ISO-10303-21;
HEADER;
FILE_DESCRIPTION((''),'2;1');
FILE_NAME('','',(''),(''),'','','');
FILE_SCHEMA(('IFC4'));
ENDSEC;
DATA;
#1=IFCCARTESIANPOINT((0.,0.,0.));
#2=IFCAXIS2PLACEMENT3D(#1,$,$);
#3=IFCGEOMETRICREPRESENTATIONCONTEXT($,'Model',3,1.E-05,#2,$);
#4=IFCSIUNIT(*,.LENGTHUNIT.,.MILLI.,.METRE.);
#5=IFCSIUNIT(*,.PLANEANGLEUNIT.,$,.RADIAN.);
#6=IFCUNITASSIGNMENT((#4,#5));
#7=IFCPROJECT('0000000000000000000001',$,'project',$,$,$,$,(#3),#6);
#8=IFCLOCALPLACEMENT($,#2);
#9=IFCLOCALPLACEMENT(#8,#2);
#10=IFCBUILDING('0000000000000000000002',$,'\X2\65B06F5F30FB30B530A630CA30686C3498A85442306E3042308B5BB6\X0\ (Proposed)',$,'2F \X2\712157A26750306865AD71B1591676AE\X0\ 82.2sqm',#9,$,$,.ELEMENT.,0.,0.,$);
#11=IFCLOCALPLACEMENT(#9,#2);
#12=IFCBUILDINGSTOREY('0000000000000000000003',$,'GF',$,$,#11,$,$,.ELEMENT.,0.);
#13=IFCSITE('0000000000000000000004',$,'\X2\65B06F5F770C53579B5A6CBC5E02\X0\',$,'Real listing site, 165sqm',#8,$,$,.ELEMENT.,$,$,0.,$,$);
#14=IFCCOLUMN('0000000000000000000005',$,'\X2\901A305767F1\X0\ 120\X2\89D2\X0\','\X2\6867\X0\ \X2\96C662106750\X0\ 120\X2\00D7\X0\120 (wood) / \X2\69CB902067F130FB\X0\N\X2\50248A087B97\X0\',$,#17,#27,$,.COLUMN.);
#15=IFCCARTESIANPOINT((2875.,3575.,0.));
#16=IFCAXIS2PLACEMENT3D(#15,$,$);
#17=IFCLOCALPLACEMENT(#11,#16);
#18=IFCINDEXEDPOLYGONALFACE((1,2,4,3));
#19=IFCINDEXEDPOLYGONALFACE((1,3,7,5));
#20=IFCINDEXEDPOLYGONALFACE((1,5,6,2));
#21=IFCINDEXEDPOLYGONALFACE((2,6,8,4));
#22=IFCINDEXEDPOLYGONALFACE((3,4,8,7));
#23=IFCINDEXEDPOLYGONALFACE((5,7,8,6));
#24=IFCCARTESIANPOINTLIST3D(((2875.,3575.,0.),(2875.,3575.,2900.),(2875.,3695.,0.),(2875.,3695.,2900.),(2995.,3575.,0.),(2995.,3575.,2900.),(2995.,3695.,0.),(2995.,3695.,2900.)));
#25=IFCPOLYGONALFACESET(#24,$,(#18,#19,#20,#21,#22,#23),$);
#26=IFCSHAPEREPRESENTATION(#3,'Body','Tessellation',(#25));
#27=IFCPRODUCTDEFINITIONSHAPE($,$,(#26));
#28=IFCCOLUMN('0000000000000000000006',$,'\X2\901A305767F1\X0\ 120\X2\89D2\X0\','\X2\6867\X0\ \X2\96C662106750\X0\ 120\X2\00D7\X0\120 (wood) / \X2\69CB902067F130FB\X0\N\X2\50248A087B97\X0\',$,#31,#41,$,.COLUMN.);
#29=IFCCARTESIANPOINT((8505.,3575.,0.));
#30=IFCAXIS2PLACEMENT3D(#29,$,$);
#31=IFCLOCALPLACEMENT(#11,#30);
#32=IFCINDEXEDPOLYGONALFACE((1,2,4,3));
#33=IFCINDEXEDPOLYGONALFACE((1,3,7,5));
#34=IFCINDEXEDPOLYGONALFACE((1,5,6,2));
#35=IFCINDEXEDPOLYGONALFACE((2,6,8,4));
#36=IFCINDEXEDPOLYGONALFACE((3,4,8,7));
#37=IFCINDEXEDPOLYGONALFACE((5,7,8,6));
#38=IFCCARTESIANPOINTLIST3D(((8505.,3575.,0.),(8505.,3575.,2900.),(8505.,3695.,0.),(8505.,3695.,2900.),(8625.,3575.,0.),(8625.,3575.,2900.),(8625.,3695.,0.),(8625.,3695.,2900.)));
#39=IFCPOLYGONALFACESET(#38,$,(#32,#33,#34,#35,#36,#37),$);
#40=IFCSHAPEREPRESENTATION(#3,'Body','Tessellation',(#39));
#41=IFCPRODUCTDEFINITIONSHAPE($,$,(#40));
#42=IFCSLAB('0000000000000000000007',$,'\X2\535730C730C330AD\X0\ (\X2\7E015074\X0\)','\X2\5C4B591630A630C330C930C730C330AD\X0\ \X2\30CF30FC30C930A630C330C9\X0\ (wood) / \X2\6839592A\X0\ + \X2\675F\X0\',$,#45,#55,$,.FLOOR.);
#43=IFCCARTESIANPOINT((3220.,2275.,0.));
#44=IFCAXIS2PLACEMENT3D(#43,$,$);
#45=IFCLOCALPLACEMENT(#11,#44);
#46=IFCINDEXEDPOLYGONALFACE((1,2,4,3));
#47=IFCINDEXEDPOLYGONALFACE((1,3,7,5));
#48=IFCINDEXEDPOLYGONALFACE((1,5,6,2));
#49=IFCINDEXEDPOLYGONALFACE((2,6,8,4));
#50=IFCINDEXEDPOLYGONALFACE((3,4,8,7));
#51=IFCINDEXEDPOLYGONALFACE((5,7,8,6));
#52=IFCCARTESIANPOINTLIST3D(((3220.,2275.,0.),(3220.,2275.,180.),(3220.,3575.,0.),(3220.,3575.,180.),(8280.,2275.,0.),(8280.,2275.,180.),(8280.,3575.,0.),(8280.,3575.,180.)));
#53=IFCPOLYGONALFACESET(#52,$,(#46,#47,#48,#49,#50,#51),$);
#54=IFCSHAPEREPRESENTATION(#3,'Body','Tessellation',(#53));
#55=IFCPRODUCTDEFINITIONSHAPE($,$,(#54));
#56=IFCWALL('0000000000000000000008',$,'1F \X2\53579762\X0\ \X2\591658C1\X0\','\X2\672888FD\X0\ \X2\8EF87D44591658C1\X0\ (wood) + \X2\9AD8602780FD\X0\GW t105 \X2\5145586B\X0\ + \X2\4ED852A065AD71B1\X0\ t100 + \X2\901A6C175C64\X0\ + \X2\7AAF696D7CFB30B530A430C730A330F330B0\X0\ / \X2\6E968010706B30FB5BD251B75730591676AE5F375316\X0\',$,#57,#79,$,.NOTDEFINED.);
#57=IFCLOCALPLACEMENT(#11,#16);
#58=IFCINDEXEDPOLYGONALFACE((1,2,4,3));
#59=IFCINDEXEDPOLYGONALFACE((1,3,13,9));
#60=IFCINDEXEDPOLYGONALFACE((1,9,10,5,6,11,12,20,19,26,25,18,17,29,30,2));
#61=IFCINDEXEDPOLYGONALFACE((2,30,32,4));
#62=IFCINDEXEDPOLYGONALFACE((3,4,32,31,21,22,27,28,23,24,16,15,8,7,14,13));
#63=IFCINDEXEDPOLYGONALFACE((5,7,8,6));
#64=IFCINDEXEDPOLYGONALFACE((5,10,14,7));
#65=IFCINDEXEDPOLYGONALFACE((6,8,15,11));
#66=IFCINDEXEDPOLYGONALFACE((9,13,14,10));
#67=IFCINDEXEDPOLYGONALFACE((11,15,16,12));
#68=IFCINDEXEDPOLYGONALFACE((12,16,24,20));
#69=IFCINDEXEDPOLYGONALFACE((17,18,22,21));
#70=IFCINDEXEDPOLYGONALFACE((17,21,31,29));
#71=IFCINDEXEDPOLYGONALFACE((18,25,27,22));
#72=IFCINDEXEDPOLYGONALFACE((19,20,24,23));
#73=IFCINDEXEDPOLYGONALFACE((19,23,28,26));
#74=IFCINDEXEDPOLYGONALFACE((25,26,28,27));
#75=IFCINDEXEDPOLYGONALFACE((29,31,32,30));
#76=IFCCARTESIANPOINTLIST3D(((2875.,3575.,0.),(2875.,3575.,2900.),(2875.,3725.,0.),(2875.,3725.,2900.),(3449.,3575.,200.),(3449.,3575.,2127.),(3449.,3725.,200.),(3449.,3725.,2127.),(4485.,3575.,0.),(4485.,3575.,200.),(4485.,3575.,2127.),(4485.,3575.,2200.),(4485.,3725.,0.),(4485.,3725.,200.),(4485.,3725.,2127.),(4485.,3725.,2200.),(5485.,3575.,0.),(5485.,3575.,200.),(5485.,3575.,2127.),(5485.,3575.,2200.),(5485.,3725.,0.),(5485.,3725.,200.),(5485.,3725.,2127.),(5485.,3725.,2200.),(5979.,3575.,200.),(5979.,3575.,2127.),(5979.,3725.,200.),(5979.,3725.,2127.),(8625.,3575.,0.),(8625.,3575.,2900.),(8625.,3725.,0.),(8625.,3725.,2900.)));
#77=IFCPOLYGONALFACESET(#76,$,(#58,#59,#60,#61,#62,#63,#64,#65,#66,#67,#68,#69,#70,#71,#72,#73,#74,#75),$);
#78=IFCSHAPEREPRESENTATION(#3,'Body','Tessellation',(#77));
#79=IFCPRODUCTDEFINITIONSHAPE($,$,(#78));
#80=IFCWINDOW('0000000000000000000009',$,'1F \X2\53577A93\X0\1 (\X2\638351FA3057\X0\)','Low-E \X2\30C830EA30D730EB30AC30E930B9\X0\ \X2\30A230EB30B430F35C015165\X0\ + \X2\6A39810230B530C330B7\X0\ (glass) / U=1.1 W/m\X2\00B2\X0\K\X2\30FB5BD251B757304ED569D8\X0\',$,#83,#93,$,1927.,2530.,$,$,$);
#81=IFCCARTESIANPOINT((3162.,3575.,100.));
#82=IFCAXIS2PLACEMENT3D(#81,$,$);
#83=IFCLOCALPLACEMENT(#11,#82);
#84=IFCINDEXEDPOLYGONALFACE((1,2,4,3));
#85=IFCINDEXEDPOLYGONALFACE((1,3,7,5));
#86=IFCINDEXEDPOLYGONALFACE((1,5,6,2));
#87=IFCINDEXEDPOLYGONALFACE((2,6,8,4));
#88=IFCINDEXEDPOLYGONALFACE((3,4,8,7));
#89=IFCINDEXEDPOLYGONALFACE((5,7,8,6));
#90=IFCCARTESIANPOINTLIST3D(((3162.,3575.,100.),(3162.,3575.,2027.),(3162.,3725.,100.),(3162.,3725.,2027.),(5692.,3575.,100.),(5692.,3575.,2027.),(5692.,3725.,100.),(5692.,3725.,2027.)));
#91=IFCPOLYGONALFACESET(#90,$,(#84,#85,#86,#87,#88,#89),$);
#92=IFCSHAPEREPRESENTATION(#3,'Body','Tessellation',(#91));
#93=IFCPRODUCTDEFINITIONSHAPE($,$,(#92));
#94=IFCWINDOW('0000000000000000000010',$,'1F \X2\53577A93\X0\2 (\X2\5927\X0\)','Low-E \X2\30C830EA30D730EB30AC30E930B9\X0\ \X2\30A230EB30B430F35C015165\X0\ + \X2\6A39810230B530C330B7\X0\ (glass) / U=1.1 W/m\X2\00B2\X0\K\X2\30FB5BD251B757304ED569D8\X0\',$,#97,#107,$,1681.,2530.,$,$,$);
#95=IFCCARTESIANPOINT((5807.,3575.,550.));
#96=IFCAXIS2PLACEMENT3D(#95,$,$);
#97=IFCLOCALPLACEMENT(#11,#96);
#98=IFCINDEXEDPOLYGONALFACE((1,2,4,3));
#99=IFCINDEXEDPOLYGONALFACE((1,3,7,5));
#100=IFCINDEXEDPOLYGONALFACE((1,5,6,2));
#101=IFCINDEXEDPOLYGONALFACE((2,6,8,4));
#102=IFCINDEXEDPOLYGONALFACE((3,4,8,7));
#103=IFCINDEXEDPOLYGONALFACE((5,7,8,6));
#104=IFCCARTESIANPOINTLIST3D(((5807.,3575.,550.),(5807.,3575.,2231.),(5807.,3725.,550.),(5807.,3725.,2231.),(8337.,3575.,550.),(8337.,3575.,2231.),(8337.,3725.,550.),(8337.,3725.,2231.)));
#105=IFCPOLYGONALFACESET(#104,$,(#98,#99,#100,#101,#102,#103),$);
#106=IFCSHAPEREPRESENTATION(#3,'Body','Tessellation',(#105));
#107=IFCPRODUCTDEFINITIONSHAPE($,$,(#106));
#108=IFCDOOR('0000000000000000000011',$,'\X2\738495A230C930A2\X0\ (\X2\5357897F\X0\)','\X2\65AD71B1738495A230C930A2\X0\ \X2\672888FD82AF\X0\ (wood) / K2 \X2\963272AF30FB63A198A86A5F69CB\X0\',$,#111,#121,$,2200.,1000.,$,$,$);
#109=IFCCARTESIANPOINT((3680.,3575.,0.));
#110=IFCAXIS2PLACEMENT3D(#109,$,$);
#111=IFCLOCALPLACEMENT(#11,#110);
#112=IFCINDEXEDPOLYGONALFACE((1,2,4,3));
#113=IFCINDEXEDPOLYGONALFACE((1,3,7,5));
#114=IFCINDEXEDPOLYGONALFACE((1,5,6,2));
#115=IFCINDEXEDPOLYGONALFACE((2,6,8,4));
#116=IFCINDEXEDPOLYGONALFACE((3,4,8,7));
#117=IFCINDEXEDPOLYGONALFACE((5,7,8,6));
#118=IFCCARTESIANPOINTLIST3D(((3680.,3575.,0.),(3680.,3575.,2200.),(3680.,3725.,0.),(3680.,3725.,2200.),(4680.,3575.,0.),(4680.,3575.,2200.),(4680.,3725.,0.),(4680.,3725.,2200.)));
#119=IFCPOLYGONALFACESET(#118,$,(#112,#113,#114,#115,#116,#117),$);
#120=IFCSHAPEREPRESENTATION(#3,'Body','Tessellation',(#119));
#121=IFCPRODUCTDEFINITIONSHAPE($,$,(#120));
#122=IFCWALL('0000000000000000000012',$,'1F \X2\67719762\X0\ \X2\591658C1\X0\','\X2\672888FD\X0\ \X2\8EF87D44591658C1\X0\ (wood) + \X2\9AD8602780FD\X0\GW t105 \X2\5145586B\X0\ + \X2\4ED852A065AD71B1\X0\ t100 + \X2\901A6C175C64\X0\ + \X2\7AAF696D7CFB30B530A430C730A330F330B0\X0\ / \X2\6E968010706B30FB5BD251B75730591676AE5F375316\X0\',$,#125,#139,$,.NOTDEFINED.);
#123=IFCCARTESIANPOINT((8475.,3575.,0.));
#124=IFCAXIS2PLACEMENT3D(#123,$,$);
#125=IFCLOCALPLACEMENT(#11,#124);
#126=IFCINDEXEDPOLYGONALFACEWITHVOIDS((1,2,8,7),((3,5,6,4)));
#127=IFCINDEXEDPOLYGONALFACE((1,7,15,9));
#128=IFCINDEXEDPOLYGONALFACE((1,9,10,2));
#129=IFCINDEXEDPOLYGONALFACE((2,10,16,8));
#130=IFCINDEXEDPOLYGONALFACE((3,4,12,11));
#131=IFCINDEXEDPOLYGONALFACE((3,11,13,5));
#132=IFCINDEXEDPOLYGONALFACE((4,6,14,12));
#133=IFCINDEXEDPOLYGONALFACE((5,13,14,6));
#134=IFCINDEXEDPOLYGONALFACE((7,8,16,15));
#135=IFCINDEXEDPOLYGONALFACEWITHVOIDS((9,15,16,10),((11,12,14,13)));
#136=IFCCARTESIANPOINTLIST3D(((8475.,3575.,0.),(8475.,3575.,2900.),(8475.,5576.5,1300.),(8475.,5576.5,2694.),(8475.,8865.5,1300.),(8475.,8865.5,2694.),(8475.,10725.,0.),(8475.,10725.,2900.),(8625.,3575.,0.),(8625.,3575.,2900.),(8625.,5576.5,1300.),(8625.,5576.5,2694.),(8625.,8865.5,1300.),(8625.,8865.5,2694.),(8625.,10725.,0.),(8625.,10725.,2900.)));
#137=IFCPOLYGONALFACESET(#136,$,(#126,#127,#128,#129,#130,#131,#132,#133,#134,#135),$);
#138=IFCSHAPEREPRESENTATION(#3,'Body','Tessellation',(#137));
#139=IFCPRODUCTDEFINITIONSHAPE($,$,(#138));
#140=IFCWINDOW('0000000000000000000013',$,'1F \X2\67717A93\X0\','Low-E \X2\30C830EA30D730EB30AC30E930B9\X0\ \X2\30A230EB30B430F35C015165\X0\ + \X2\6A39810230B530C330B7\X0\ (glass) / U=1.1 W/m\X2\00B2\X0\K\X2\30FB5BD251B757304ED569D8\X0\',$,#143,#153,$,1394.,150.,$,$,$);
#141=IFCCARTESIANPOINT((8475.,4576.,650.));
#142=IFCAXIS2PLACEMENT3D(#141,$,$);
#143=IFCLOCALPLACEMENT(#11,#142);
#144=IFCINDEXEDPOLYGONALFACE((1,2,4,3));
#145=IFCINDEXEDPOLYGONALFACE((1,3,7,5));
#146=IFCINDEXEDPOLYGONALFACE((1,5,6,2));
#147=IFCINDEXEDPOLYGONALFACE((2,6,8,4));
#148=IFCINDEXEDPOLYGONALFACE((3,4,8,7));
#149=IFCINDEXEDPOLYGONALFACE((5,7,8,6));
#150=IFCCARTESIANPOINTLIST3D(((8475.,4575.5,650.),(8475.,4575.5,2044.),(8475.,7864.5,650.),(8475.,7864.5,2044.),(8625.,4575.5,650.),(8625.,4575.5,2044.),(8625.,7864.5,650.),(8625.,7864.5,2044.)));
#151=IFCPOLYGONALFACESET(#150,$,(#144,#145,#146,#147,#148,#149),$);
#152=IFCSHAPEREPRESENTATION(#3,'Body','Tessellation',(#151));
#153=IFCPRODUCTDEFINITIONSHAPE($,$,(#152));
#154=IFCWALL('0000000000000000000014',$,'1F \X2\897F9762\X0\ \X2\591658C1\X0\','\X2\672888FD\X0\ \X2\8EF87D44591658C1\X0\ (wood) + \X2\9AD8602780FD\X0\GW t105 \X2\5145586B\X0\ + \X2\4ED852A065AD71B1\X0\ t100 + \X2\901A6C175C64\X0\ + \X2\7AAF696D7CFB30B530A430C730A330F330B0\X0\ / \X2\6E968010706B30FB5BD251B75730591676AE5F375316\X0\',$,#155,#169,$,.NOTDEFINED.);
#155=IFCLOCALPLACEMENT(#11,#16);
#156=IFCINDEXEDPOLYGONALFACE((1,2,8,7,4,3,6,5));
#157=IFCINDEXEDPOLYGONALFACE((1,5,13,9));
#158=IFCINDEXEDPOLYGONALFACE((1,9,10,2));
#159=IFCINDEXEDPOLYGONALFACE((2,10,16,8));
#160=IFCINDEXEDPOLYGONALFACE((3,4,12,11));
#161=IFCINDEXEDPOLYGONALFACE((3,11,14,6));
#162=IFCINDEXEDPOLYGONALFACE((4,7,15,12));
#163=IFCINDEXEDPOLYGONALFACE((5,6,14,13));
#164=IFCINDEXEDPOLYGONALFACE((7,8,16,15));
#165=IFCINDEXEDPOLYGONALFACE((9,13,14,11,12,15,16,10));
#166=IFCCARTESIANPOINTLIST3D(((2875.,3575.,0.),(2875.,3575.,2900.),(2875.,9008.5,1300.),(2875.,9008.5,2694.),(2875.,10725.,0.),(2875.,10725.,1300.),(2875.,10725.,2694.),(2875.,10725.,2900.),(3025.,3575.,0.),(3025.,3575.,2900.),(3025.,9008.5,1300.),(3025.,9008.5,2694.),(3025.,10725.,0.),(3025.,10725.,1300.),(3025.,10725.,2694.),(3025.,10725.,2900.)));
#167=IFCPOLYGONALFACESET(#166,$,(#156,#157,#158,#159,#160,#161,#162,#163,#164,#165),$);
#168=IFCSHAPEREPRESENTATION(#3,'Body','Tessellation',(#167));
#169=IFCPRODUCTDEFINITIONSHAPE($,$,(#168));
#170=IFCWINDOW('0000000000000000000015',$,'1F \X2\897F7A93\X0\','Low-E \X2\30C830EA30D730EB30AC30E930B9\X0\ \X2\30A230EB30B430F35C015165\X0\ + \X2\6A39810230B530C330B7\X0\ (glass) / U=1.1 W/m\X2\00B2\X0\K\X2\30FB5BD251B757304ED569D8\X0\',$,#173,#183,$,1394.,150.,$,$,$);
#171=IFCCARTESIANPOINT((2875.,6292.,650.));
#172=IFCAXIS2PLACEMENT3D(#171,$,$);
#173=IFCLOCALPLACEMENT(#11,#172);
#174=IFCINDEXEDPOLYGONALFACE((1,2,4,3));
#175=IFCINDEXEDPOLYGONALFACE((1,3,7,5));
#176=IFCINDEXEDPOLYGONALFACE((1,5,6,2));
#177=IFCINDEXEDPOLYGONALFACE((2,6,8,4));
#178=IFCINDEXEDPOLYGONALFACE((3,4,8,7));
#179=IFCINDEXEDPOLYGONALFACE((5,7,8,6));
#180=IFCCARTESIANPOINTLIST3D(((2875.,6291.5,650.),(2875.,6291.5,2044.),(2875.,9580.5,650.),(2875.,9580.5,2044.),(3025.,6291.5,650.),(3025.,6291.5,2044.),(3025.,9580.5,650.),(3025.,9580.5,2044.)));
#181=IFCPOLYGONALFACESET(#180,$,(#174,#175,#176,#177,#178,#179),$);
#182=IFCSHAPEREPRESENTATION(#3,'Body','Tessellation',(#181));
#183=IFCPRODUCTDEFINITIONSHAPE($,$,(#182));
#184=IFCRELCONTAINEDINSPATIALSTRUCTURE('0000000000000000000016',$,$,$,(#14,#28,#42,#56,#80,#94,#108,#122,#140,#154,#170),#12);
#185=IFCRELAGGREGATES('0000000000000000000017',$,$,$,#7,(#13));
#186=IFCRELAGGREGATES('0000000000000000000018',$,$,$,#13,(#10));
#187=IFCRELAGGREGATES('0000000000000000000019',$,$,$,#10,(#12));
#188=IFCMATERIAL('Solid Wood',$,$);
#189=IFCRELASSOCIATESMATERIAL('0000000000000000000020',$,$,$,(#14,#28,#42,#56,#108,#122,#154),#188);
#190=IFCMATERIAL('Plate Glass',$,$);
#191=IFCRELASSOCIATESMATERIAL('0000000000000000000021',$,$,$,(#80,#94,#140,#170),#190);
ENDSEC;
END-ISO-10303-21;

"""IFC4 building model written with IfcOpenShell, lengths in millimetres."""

from ifc_helpers import new_model, si_unit, frame, frame_2d, origin, place, context, project, spatial, rectangle, extrude, material, element, fill, save


model = new_model("IFC4")

# Units and contexts
model_context = context("Model", 3, precision=1e-05, world=origin())
ifc_project = project(units=[si_unit("LENGTHUNIT", "METRE", prefix="MILLI"), si_unit("PLANEANGLEUNIT", "RADIAN")], contexts=[model_context])

# Site, building, storey
site_placement = place(None, origin())
site = spatial("IfcSite", under=ifc_project, at=site_placement, Name="新潟県南魚沼市", ObjectType="Real listing site, 165sqm", CompositionType="ELEMENT", RefElevation=0.0)
building_placement = place(site_placement, origin())
building = spatial("IfcBuilding", under=site, at=building_placement, Name="新潟・サウナと水風呂のある家 (Proposed)", ObjectType="2F 無垢材と断熱外皮 82.2sqm", CompositionType="ELEMENT", ElevationOfRefHeight=0.0, ElevationOfTerrain=0.0)
storey_placement = place(building_placement, origin())
storey = spatial("IfcBuildingStorey", under=building, at=storey_placement, Name="GF", CompositionType="ELEMENT", Elevation=0.0)

# Columns
ifc_material_1 = material(Name="Solid Wood")
column_1_placement = place(storey_placement, frame((2875.0, 3575.0, 0.0)))
element("IfcColumn", 1, at=column_1_placement, inside=storey, material=ifc_material_1, Name="通し柱 120角", Description="桧 集成材 120×120 (wood) / 構造柱・N値計算", PredefinedType="COLUMN", context=model_context, shape_type="SweptSolid", body=[
    extrude(rectangle(XDim=120.0, YDim=120.0, at=frame_2d((60.0, 60.0))), frame((2875.0, 3575.0, 0.0)), (0.0, 0.0, 1.0), 2900.0),
])
column_2_placement = place(storey_placement, frame((8505.0, 3575.0, 0.0)))
element("IfcColumn", 2, at=column_2_placement, inside=storey, material=ifc_material_1, Name="通し柱 120角", Description="桧 集成材 120×120 (wood) / 構造柱・N値計算", PredefinedType="COLUMN", context=model_context, shape_type="SweptSolid", body=[
    extrude(rectangle(XDim=120.0, YDim=120.0, at=frame_2d((60.0, 60.0))), frame((8505.0, 3575.0, 0.0)), (0.0, 0.0, 1.0), 2900.0),
])

# Slab
slab_1_placement = place(storey_placement, frame((3220.0, 2275.0, 0.0)))
element("IfcSlab", 3, at=slab_1_placement, inside=storey, material=ifc_material_1, Name="南デッキ (縁側)", Description="屋外ウッドデッキ ハードウッド (wood) / 根太 + 束", PredefinedType="FLOOR", context=model_context, shape_type="SweptSolid", body=[
    extrude(rectangle(XDim=5060.0, YDim=1300.0, at=frame_2d((2530.0, 650.0))), frame((3220.0, 2275.0, 0.0)), (0.0, 0.0, 1.0), 180.0),
])

# Wall, openings, windows, door
wall_1_placement = place(storey_placement, frame((2875.0, 3575.0, 0.0)))
wall_1 = element("IfcWall", 4, at=wall_1_placement, inside=storey, material=ifc_material_1, Name="1F 南面 外壁", Description="木製 軸組外壁 (wood) + 高性能GW t105 充填 + 付加断熱 t100 + 通気層 + 窯業系サイディング / 準耐火・寒冷地外皮強化", PredefinedType="NOTDEFINED", context=model_context, shape_type="SweptSolid", body=[
    extrude(rectangle(XDim=5750.0, YDim=150.0, at=frame_2d((2875.0, 75.0))), frame((2875.0, 3575.0, 0.0)), (0.0, 0.0, 1.0), 2900.0),
])
opening_1_placement = place(storey_placement, frame((3162.0, 3575.0, 100.0)))
opening_1 = element("IfcOpeningElement", 5, at=opening_1_placement, cuts=wall_1, PredefinedType="NOTDEFINED", context=model_context, shape_type="SweptSolid", body=[
    extrude(rectangle(XDim=2530.0, YDim=150.0, at=frame_2d((1265.0, 75.0))), frame((3162.0, 3575.0, 100.0)), (0.0, 0.0, 1.0), 1927.0),
])
opening_2_placement = place(storey_placement, frame((5807.0, 3575.0, 550.0)))
opening_2 = element("IfcOpeningElement", 6, at=opening_2_placement, cuts=wall_1, PredefinedType="NOTDEFINED", context=model_context, shape_type="SweptSolid", body=[
    extrude(rectangle(XDim=2530.0, YDim=150.0, at=frame_2d((1265.0, 75.0))), frame((5807.0, 3575.0, 550.0)), (0.0, 0.0, 1.0), 1681.0),
])
opening_3_placement = place(storey_placement, frame((3680.0, 3575.0, 0.0)))
opening_3 = element("IfcOpeningElement", 7, at=opening_3_placement, cuts=wall_1, PredefinedType="NOTDEFINED", context=model_context, shape_type="SweptSolid", body=[
    extrude(rectangle(XDim=1000.0, YDim=150.0, at=frame_2d((500.0, 75.0))), frame((3680.0, 3575.0, 0.0)), (0.0, 0.0, 1.0), 2200.0),
])
ifc_material_2 = material(Name="Plate Glass")
window_1_placement = place(storey_placement, frame((3162.0, 3575.0, 100.0)))
window_1 = element("IfcWindow", 8, at=window_1_placement, inside=storey, material=ifc_material_2, Name="1F 南窓1 (掃出し)", Description="Low-E トリプルガラス アルゴン封入 + 樹脂サッシ (glass) / U=1.1 W/m²K・寒冷地仕様", OverallHeight=1927.0, OverallWidth=2530.0, context=model_context, shape_type="SweptSolid", body=[
    extrude(rectangle(XDim=2530.0, YDim=150.0, at=frame_2d((1265.0, 75.0))), frame((3162.0, 3575.0, 100.0)), (0.0, 0.0, 1.0), 1927.0),
])
fill(opening_1, window_1)
window_2_placement = place(storey_placement, frame((5807.0, 3575.0, 550.0)))
window_2 = element("IfcWindow", 9, at=window_2_placement, inside=storey, material=ifc_material_2, Name="1F 南窓2 (大)", Description="Low-E トリプルガラス アルゴン封入 + 樹脂サッシ (glass) / U=1.1 W/m²K・寒冷地仕様", OverallHeight=1681.0, OverallWidth=2530.0, context=model_context, shape_type="SweptSolid", body=[
    extrude(rectangle(XDim=2530.0, YDim=150.0, at=frame_2d((1265.0, 75.0))), frame((5807.0, 3575.0, 550.0)), (0.0, 0.0, 1.0), 1681.0),
])
fill(opening_2, window_2)
door_placement = place(storey_placement, frame((3680.0, 3575.0, 0.0)))
door = element("IfcDoor", 10, at=door_placement, inside=storey, material=ifc_material_1, Name="玄関ドア (南西)", Description="断熱玄関ドア 木製芯 (wood) / K2 防犯・採風機構", OverallHeight=2200.0, OverallWidth=1000.0, context=model_context, shape_type="SweptSolid", body=[
    extrude(rectangle(XDim=1000.0, YDim=150.0, at=frame_2d((500.0, 75.0))), frame((3680.0, 3575.0, 0.0)), (0.0, 0.0, 1.0), 2200.0),
])
fill(opening_3, door)

# Walls, openings, windows
wall_2_placement = place(storey_placement, frame((8475.0, 3575.0, 0.0)))
wall_2 = element("IfcWall", 11, at=wall_2_placement, inside=storey, material=ifc_material_1, Name="1F 東面 外壁", Description="木製 軸組外壁 (wood) + 高性能GW t105 充填 + 付加断熱 t100 + 通気層 + 窯業系サイディング / 準耐火・寒冷地外皮強化", PredefinedType="NOTDEFINED", context=model_context, shape_type="SweptSolid", body=[
    extrude(rectangle(XDim=150.0, YDim=7150.0, at=frame_2d((75.0, 3575.0))), frame((8475.0, 3575.0, 0.0)), (0.0, 0.0, 1.0), 2900.0),
])
opening_4_placement = place(storey_placement, frame((8475.0, 4576.0, 650.0)))
opening_4 = element("IfcOpeningElement", 12, at=opening_4_placement, cuts=wall_2, PredefinedType="NOTDEFINED", context=model_context, shape_type="SweptSolid", body=[
    extrude(rectangle(XDim=150.0, YDim=3289.0, at=frame_2d((75.0, 1644.0))), frame((8475.0, 4576.0, 650.0)), (0.0, 0.0, 1.0), 1394.0),
])
window_3_placement = place(storey_placement, frame((8475.0, 4576.0, 650.0)))
window_3 = element("IfcWindow", 13, at=window_3_placement, inside=storey, material=ifc_material_2, Name="1F 東窓", Description="Low-E トリプルガラス アルゴン封入 + 樹脂サッシ (glass) / U=1.1 W/m²K・寒冷地仕様", OverallHeight=1394.0, OverallWidth=150.0, context=model_context, shape_type="SweptSolid", body=[
    extrude(rectangle(XDim=150.0, YDim=3289.0, at=frame_2d((75.0, 1644.0))), frame((8475.0, 4576.0, 650.0)), (0.0, 0.0, 1.0), 1394.0),
])
fill(opening_4, window_3)
wall_3_placement = place(storey_placement, frame((2875.0, 3575.0, 0.0)))
wall_3 = element("IfcWall", 14, at=wall_3_placement, inside=storey, material=ifc_material_1, Name="1F 西面 外壁", Description="木製 軸組外壁 (wood) + 高性能GW t105 充填 + 付加断熱 t100 + 通気層 + 窯業系サイディング / 準耐火・寒冷地外皮強化", PredefinedType="NOTDEFINED", context=model_context, shape_type="SweptSolid", body=[
    extrude(rectangle(XDim=150.0, YDim=7150.0, at=frame_2d((75.0, 3575.0))), frame((2875.0, 3575.0, 0.0)), (0.0, 0.0, 1.0), 2900.0),
])
opening_5_placement = place(storey_placement, frame((2875.0, 6292.0, 650.0)))
opening_5 = element("IfcOpeningElement", 15, at=opening_5_placement, cuts=wall_3, PredefinedType="NOTDEFINED", context=model_context, shape_type="SweptSolid", body=[
    extrude(rectangle(XDim=150.0, YDim=3289.0, at=frame_2d((75.0, 1644.0))), frame((2875.0, 6292.0, 650.0)), (0.0, 0.0, 1.0), 1394.0),
])
window_4_placement = place(storey_placement, frame((2875.0, 6292.0, 650.0)))
window_4 = element("IfcWindow", 16, at=window_4_placement, inside=storey, material=ifc_material_2, Name="1F 西窓", Description="Low-E トリプルガラス アルゴン封入 + 樹脂サッシ (glass) / U=1.1 W/m²K・寒冷地仕様", OverallHeight=1394.0, OverallWidth=150.0, context=model_context, shape_type="SweptSolid", body=[
    extrude(rectangle(XDim=150.0, YDim=3289.0, at=frame_2d((75.0, 1644.0))), frame((2875.0, 6292.0, 650.0)), (0.0, 0.0, 1.0), 1394.0),
])
fill(opening_5, window_4)

save(model, "model.ifc")
